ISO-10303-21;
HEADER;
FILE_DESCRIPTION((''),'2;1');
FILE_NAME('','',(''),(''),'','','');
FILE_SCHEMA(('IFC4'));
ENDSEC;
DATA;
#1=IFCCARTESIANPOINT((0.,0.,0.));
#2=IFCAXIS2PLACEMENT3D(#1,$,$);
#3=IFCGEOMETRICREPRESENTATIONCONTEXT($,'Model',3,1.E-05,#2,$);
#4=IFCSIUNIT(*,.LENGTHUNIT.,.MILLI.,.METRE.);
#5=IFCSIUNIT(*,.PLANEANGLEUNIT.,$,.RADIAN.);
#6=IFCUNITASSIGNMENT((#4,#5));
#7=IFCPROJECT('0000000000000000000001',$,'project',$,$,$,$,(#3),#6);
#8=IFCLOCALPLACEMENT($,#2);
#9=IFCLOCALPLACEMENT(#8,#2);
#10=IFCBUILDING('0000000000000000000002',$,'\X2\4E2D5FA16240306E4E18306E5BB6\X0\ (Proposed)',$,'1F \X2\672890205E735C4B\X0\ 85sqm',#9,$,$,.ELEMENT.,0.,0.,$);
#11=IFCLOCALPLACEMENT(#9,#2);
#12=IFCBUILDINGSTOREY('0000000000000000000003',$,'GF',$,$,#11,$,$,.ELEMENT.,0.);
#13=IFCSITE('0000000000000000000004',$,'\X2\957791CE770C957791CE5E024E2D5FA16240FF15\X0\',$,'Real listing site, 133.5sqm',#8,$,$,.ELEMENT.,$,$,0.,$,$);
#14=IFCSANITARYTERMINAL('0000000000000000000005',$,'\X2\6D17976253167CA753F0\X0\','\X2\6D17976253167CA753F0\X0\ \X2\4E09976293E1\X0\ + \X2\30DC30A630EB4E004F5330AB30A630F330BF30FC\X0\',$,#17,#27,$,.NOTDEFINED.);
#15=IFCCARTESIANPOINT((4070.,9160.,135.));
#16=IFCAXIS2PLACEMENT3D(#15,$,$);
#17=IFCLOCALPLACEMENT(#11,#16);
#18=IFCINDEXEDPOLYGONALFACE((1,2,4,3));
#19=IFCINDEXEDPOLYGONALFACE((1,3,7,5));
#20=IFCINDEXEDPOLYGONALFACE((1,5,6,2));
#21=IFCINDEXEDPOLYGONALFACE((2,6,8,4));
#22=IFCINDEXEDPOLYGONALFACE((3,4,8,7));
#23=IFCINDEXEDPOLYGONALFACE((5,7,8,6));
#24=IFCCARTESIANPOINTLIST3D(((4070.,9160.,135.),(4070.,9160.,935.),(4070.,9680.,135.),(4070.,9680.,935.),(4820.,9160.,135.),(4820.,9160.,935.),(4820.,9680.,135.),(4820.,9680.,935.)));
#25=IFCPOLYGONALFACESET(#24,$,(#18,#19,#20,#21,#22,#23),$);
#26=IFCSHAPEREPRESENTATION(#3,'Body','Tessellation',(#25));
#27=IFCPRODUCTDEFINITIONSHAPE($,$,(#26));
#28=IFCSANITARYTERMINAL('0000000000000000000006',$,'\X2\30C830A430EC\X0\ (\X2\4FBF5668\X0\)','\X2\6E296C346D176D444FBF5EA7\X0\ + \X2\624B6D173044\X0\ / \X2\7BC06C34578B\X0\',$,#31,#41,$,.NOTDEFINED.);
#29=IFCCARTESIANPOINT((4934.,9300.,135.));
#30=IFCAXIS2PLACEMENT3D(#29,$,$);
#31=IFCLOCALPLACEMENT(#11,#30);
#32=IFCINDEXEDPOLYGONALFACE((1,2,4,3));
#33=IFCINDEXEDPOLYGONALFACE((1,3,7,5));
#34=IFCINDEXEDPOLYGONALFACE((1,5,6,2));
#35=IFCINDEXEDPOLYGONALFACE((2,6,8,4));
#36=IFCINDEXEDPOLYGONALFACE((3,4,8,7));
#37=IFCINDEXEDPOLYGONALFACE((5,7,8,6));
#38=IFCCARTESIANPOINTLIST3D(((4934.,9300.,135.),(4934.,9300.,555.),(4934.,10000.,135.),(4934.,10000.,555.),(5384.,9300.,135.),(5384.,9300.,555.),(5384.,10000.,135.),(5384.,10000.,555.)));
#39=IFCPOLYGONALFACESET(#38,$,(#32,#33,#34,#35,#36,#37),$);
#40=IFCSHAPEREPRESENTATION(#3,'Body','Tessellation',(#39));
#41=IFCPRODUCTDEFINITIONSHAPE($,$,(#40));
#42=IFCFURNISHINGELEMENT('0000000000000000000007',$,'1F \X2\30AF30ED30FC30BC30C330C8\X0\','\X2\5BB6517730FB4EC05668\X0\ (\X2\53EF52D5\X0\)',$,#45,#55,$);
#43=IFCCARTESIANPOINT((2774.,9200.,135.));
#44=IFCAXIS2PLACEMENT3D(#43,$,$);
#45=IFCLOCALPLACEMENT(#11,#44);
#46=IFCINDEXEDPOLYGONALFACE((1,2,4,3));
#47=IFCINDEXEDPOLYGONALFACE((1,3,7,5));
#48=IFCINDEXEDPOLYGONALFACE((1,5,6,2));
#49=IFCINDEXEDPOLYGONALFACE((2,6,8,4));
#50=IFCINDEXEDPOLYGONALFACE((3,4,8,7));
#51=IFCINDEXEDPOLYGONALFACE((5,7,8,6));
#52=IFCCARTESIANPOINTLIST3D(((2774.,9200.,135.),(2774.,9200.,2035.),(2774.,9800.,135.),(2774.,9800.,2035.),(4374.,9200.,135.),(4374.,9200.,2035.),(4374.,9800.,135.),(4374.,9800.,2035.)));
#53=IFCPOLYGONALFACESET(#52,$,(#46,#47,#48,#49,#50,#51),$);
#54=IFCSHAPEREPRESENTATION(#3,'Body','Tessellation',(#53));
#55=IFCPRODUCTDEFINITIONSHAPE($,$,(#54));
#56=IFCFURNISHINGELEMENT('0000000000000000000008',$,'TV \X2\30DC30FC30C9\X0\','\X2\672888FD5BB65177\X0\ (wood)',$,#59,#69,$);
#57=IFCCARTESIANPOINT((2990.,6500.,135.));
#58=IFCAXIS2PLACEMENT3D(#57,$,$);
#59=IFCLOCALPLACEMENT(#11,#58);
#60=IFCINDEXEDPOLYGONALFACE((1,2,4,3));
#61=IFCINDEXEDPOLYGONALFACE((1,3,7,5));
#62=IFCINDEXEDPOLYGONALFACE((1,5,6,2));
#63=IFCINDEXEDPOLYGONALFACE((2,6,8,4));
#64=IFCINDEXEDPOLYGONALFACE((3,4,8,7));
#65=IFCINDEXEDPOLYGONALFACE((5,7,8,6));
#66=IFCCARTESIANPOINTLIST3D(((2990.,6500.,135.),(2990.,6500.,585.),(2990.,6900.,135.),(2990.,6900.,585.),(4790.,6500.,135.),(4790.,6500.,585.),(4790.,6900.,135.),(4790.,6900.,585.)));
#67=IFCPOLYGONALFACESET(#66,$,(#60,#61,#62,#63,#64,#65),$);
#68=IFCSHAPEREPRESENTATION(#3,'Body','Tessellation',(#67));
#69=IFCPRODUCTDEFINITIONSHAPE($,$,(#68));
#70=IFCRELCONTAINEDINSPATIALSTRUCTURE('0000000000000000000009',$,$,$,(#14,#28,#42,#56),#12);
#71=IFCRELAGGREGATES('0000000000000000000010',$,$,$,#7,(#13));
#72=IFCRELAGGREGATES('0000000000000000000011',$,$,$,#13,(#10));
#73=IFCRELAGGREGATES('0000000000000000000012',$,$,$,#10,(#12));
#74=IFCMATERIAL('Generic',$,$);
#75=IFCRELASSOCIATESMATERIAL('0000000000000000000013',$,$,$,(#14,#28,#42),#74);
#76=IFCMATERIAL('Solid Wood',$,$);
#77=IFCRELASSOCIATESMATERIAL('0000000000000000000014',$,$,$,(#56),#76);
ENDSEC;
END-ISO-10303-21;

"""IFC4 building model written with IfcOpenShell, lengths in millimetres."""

from ifc_helpers import new_model, si_unit, frame, frame_2d, origin, place, context, project, spatial, rectangle, extrude, material, element, save


model = new_model("IFC4")

# Units and contexts
model_context = context("Model", 3, precision=1e-05, world=origin())
ifc_project = project(units=[si_unit("LENGTHUNIT", "METRE", prefix="MILLI"), si_unit("PLANEANGLEUNIT", "RADIAN")], contexts=[model_context])

# Site, building, storey
site_placement = place(None, origin())
site = spatial("IfcSite", under=ifc_project, at=site_placement, Name="長野県長野市中御所５", ObjectType="Real listing site, 133.5sqm", CompositionType="ELEMENT", RefElevation=0.0)
building_placement = place(site_placement, origin())
building = spatial("IfcBuilding", under=site, at=building_placement, Name="中御所の丘の家 (Proposed)", ObjectType="1F 木造平屋 85sqm", CompositionType="ELEMENT", ElevationOfRefHeight=0.0, ElevationOfTerrain=0.0)
storey_placement = place(building_placement, origin())
storey = spatial("IfcBuildingStorey", under=building, at=storey_placement, Name="GF", CompositionType="ELEMENT", Elevation=0.0)

# Shared definitions
ifc_material_1 = material(Name="Solid Wood")

# Shared definitions
ifc_material_2 = material(Name="Generic")

# Sanitary terminals
sanitary_terminal_1_placement = place(storey_placement, frame((4070.0, 9160.0, 135.0)))
element("IfcSanitaryTerminal", 1, at=sanitary_terminal_1_placement, inside=storey, material=ifc_material_2, Name="洗面化粧台", Description="洗面化粧台 三面鏡 + ボウル一体カウンター", PredefinedType="NOTDEFINED", context=model_context, shape_type="SweptSolid", body=[
    extrude(rectangle(XDim=750.0, YDim=520.0, at=frame_2d((375.0, 260.0))), frame((4070.0, 9160.0, 135.0)), (0.0, 0.0, 1.0), 800.0),
])
sanitary_terminal_2_placement = place(storey_placement, frame((4934.0, 9300.0, 135.0)))
element("IfcSanitaryTerminal", 2, at=sanitary_terminal_2_placement, inside=storey, material=ifc_material_2, Name="トイレ (便器)", Description="温水洗浄便座 + 手洗い / 節水型", PredefinedType="NOTDEFINED", context=model_context, shape_type="SweptSolid", body=[
    extrude(rectangle(XDim=450.0, YDim=700.0, at=frame_2d((225.0, 350.0))), frame((4934.0, 9300.0, 135.0)), (0.0, 0.0, 1.0), 420.0),
])

# Furnishing elements
furnishing_1_placement = place(storey_placement, frame((2774.0, 9200.0, 135.0)))
element("IfcFurnishingElement", 3, at=furnishing_1_placement, inside=storey, material=ifc_material_2, Name="1F クローゼット", Description="家具・什器 (可動)", context=model_context, shape_type="SweptSolid", body=[
    extrude(rectangle(XDim=1600.0, YDim=600.0, at=frame_2d((800.0, 300.0))), frame((2774.0, 9200.0, 135.0)), (0.0, 0.0, 1.0), 1900.0),
])
furnishing_2_placement = place(storey_placement, frame((2990.0, 6500.0, 135.0)))
element("IfcFurnishingElement", 4, at=furnishing_2_placement, inside=storey, material=ifc_material_1, Name="TV ボード", Description="木製家具 (wood)", context=model_context, shape_type="SweptSolid", body=[
    extrude(rectangle(XDim=1800.0, YDim=400.0, at=frame_2d((900.0, 200.0))), frame((2990.0, 6500.0, 135.0)), (0.0, 0.0, 1.0), 450.0),
])

save(model, "model.ifc")
